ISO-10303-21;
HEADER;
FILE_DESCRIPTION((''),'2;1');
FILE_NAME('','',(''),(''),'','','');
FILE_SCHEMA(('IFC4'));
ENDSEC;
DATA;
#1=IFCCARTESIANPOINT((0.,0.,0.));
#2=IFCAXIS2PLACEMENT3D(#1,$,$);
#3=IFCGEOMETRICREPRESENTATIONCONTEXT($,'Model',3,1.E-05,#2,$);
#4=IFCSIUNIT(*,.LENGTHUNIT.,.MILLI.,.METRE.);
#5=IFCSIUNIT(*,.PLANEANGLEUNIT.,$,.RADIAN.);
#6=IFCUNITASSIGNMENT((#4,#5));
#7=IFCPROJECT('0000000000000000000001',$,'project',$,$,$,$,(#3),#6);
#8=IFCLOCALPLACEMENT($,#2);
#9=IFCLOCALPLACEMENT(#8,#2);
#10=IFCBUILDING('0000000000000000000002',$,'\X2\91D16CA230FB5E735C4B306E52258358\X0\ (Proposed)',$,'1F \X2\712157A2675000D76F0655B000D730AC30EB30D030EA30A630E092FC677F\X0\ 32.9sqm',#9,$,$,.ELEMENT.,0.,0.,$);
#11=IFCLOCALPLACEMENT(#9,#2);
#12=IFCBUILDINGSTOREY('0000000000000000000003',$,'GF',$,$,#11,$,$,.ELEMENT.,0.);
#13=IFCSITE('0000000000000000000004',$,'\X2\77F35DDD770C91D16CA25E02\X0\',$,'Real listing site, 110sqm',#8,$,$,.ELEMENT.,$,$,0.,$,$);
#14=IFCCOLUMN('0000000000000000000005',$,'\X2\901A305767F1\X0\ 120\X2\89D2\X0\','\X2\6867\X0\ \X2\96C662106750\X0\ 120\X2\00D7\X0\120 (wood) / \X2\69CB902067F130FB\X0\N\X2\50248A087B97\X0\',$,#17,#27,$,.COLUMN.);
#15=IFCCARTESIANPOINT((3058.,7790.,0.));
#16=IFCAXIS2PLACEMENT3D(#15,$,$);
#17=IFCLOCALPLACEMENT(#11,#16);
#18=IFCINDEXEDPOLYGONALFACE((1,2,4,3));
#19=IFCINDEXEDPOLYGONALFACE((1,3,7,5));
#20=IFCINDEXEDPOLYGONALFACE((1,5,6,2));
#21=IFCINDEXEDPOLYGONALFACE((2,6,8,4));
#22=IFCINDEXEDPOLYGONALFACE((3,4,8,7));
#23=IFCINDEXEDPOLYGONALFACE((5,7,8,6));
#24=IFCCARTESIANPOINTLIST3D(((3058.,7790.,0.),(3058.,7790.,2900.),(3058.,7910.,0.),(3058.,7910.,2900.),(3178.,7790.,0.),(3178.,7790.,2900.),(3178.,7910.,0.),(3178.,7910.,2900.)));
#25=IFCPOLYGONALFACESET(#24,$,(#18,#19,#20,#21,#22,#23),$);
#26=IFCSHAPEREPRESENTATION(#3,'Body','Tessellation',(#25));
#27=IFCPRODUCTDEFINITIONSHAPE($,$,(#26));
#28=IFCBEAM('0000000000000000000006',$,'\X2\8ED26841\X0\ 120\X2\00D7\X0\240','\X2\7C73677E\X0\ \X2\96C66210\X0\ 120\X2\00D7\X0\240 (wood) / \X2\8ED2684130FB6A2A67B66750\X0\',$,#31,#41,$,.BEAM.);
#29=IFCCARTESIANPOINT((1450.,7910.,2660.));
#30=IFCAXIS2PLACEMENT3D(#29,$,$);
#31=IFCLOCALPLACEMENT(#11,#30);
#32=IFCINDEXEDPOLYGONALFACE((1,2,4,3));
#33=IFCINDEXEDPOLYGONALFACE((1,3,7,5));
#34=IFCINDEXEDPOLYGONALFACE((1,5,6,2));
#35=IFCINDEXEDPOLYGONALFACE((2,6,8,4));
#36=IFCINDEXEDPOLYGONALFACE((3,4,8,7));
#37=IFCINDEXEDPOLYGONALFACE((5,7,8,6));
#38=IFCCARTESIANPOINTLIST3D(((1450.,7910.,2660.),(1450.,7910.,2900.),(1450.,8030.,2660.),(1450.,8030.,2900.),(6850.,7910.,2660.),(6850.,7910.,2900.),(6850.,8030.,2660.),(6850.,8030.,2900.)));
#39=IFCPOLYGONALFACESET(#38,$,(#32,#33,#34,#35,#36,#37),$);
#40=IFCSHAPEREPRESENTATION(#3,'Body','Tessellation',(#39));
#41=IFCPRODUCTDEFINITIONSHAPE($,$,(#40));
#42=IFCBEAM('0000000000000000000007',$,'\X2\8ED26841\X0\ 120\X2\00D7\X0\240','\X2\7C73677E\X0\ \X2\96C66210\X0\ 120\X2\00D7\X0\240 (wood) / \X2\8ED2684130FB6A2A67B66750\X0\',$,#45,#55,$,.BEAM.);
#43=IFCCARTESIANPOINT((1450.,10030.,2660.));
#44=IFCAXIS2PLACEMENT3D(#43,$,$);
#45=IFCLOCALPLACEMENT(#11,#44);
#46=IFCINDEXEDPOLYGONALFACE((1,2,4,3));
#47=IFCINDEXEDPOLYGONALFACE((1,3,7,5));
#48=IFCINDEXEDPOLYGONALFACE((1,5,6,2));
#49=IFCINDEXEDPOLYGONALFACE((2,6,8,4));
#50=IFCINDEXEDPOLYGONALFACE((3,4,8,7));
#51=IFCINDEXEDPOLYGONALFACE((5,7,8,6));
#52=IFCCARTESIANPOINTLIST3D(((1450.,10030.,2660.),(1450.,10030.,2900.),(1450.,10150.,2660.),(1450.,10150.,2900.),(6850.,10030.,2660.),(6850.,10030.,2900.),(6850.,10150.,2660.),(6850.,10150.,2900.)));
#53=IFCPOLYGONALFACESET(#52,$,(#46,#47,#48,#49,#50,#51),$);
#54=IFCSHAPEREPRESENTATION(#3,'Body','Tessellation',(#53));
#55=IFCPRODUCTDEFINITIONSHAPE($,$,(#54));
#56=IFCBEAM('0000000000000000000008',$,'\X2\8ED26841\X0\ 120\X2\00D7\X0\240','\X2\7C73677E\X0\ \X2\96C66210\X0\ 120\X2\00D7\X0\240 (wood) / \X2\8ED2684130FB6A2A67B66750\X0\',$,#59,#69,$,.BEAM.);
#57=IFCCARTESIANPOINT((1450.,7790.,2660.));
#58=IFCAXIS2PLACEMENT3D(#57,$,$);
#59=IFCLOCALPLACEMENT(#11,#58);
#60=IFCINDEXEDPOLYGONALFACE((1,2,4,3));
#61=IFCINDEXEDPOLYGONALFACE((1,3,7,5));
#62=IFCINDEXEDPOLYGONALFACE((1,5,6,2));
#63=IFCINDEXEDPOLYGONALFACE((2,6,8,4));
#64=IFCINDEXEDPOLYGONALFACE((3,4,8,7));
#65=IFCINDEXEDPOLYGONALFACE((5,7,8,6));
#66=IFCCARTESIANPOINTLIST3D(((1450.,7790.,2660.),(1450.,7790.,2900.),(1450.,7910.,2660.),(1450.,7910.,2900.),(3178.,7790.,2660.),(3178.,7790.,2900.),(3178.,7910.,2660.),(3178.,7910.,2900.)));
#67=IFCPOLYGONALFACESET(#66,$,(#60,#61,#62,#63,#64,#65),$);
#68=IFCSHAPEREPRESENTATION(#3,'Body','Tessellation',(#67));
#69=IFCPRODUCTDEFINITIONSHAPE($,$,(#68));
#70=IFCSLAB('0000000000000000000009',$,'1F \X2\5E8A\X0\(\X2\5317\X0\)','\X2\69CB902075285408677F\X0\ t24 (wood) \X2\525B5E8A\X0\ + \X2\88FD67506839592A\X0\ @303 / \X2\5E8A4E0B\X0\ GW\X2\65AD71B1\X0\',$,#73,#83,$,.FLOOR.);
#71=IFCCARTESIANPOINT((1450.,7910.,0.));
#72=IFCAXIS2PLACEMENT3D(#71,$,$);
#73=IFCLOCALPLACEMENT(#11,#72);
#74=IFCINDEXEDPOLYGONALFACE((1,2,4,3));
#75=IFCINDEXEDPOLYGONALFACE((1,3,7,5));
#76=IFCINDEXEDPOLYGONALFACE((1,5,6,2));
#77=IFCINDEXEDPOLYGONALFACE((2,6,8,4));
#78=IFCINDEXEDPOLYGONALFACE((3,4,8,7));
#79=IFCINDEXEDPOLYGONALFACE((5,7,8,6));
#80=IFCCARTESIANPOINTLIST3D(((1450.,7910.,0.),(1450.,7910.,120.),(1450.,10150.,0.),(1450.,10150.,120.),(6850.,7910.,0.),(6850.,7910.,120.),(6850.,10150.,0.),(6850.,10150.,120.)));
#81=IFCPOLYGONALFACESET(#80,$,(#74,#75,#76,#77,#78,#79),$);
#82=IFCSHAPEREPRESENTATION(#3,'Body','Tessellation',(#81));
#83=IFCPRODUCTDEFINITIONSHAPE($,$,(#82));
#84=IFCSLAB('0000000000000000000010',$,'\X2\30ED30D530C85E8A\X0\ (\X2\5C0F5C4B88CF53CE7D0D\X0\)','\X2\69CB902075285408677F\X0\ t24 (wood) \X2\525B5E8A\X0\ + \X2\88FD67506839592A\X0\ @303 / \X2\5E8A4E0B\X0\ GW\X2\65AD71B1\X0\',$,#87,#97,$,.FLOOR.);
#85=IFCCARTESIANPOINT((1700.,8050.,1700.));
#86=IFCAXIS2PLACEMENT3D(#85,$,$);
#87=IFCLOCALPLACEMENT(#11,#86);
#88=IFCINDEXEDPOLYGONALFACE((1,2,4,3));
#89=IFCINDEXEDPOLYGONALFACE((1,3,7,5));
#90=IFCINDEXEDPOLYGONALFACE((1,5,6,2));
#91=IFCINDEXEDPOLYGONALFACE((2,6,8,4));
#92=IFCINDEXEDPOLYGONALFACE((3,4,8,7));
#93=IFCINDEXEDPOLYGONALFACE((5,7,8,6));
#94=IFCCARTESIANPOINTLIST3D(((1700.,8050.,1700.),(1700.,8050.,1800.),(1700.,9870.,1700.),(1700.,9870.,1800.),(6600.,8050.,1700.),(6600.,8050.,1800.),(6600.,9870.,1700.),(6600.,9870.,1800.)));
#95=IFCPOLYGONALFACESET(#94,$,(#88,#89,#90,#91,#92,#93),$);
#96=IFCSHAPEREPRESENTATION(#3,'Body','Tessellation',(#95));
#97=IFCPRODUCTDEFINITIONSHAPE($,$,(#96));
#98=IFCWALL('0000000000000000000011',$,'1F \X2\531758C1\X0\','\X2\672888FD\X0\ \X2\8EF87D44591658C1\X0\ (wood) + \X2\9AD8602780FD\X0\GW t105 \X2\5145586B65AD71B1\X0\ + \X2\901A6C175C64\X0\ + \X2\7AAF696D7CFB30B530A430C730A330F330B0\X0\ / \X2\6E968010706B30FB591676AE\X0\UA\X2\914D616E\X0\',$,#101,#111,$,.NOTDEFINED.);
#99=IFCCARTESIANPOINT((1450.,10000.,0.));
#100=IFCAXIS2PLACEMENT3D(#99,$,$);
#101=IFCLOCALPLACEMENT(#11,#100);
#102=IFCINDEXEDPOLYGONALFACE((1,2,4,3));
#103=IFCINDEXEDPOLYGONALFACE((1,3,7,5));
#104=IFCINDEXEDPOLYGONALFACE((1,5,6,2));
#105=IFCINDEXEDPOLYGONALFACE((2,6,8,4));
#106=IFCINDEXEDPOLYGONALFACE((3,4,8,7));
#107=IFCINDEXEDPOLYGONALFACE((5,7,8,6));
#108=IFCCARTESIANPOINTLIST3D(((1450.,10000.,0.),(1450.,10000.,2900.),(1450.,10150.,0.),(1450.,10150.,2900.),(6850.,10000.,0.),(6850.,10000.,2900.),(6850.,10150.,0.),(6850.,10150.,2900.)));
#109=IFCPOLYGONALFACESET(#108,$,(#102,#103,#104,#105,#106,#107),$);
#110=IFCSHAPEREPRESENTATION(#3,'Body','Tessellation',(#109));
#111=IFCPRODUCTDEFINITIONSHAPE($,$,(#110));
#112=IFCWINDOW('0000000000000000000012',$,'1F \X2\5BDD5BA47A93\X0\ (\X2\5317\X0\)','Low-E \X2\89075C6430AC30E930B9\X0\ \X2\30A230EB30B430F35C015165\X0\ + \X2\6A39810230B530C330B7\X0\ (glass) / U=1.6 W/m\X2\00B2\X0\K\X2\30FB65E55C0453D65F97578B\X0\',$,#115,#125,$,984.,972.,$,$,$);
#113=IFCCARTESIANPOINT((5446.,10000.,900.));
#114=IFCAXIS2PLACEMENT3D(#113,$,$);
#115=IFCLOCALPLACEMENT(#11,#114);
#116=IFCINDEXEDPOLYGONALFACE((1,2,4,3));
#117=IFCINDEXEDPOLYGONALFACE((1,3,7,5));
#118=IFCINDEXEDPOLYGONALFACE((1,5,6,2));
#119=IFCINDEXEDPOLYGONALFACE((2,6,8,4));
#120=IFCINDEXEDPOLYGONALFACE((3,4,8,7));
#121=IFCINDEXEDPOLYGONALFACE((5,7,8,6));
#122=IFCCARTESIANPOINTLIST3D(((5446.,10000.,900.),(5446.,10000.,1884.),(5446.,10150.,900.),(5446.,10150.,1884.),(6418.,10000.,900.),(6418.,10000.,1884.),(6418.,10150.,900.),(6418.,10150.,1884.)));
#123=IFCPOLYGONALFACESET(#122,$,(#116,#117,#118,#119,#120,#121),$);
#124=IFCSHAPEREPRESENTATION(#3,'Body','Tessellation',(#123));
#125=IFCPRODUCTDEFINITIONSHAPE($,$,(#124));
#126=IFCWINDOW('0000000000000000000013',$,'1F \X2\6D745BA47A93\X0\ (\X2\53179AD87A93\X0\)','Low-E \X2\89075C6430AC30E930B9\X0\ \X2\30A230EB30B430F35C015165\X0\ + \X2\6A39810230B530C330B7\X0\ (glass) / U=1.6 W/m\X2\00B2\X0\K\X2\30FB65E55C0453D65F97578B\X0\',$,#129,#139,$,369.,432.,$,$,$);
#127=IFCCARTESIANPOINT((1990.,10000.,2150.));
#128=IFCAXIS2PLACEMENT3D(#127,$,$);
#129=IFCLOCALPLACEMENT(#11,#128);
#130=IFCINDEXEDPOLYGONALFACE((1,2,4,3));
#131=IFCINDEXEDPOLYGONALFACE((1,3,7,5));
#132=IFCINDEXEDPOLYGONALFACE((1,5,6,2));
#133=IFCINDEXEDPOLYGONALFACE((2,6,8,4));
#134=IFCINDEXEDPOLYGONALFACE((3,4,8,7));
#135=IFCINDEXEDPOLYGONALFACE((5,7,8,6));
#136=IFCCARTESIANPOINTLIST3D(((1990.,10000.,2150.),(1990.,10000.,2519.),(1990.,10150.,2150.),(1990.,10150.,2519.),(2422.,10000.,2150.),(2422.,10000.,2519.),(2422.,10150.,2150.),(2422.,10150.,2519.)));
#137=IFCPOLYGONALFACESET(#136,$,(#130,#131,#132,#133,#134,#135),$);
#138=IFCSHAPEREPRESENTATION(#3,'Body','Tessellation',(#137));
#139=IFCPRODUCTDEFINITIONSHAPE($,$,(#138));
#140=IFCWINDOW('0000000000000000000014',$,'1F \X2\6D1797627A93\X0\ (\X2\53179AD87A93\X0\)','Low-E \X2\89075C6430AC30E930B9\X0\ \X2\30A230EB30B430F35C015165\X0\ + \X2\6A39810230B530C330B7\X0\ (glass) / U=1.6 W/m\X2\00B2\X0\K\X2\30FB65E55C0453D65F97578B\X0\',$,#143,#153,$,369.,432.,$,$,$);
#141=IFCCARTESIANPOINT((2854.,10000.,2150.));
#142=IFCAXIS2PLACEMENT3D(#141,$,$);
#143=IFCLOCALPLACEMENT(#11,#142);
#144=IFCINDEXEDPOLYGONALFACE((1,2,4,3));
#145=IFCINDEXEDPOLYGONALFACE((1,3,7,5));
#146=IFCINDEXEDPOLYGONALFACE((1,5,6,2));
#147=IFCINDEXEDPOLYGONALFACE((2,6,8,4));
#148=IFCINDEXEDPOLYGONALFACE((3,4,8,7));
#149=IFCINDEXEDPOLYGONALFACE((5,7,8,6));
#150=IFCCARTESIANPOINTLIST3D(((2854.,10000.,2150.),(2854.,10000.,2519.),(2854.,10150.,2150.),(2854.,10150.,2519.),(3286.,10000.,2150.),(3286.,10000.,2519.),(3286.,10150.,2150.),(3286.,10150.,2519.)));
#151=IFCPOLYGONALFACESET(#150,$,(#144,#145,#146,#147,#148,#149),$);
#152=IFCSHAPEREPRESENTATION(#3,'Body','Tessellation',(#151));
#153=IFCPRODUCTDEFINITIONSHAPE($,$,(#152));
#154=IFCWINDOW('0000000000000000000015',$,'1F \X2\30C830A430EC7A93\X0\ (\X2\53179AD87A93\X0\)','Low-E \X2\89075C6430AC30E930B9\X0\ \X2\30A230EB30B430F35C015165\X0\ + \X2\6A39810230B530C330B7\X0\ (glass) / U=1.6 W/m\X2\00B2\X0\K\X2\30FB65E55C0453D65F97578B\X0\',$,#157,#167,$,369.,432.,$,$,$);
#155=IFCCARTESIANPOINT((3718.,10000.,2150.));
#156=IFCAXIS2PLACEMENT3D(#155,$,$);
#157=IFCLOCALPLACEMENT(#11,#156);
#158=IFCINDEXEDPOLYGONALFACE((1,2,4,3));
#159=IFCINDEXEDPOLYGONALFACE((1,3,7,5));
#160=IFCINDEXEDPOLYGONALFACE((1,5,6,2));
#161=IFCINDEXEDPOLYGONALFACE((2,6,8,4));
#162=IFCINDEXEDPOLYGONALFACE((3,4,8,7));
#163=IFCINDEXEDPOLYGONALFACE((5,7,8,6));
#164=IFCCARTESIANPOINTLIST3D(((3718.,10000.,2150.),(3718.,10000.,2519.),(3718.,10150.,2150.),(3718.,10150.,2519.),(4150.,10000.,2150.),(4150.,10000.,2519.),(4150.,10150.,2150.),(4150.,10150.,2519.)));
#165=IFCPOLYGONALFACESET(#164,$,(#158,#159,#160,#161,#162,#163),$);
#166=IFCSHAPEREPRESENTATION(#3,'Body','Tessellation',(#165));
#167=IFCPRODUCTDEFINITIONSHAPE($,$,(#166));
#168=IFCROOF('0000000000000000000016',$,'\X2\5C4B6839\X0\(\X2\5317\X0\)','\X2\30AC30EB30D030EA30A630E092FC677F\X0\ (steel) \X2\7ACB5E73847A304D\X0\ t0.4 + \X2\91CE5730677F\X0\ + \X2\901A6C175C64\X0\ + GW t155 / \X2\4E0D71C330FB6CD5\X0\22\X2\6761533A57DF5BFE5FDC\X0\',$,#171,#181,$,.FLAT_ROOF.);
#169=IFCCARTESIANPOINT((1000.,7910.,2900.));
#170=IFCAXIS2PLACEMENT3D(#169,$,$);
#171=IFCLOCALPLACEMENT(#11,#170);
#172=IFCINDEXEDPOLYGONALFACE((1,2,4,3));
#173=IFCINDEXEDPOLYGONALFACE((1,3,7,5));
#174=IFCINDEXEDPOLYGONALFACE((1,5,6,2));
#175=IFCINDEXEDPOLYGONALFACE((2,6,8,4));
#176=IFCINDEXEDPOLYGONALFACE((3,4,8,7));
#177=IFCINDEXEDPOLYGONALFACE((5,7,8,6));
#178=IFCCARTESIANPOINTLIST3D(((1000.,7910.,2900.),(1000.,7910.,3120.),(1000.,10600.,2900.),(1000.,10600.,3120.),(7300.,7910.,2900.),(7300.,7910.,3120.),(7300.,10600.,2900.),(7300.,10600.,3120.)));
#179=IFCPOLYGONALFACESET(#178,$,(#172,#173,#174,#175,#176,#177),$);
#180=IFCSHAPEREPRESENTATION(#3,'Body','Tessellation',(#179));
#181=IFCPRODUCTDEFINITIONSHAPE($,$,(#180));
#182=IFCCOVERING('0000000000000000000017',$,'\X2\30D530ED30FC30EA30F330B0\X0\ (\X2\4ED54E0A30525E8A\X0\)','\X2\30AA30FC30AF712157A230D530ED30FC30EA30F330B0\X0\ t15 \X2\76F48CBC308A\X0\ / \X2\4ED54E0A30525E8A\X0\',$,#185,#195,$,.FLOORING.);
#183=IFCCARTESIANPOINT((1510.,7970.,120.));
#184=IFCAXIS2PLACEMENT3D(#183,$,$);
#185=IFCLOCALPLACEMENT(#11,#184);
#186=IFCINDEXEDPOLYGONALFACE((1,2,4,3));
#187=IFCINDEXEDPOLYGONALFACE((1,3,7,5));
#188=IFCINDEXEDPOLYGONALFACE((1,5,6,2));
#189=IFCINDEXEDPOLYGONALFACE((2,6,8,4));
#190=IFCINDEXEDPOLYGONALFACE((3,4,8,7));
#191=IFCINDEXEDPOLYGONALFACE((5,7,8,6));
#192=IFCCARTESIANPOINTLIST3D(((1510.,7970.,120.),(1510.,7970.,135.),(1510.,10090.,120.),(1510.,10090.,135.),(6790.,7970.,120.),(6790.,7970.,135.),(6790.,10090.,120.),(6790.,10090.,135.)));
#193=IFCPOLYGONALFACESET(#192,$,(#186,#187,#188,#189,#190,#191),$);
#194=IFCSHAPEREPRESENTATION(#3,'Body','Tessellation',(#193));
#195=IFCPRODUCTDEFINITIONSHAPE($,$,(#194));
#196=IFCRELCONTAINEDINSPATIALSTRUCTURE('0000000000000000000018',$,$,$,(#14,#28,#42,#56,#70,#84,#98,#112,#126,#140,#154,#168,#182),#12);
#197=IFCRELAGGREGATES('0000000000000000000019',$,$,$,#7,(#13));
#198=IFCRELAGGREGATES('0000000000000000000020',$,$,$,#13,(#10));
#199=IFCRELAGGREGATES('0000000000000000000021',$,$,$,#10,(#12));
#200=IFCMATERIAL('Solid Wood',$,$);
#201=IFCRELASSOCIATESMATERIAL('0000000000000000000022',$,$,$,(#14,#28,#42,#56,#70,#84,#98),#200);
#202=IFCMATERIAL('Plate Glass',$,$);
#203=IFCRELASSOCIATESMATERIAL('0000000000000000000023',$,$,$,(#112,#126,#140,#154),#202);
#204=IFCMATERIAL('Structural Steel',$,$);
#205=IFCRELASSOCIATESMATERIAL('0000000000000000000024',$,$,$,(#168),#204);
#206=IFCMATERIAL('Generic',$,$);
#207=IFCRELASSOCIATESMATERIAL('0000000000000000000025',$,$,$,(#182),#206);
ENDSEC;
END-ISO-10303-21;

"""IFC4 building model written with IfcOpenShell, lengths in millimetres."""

from ifc_helpers import new_model, si_unit, frame, frame_2d, origin, place, context, project, spatial, rectangle, extrude, material, element, fill, save


model = new_model("IFC4")

# Units and contexts
model_context = context("Model", 3, precision=1e-05, world=origin())
ifc_project = project(units=[si_unit("LENGTHUNIT", "METRE", prefix="MILLI"), si_unit("PLANEANGLEUNIT", "RADIAN")], contexts=[model_context])

# Site, building, storey
site_placement = place(None, origin())
site = spatial("IfcSite", under=ifc_project, at=site_placement, Name="石川県金沢市", ObjectType="Real listing site, 110sqm", CompositionType="ELEMENT", RefElevation=0.0)
building_placement = place(site_placement, origin())
building = spatial("IfcBuilding", under=site, at=building_placement, Name="金沢・平屋の別荘 (Proposed)", ObjectType="1F 無垢材×漆喰×ガルバリウム鋼板 32.9sqm", CompositionType="ELEMENT", ElevationOfRefHeight=0.0, ElevationOfTerrain=0.0)
storey_placement = place(building_placement, origin())
storey = spatial("IfcBuildingStorey", under=building, at=storey_placement, Name="GF", CompositionType="ELEMENT", Elevation=0.0)

# Column
ifc_material_1 = material(Name="Solid Wood")
column_1_placement = place(storey_placement, frame((3058.0, 7790.0, 0.0)))
element("IfcColumn", 1, at=column_1_placement, inside=storey, material=ifc_material_1, Name="通し柱 120角", Description="桧 集成材 120×120 (wood) / 構造柱・N値計算", PredefinedType="COLUMN", context=model_context, shape_type="SweptSolid", body=[
    extrude(rectangle(XDim=120.0, YDim=120.0, at=frame_2d((60.0, 60.0))), frame((3058.0, 7790.0, 0.0)), (0.0, 0.0, 1.0), 2900.0),
])

# Beams
beam_1_placement = place(storey_placement, frame((1450.0, 7910.0, 2660.0)))
element("IfcBeam", 2, at=beam_1_placement, inside=storey, material=ifc_material_1, Name="軒桁 120×240", Description="米松 集成 120×240 (wood) / 軒桁・横架材", PredefinedType="BEAM", context=model_context, shape_type="SweptSolid", body=[
    extrude(rectangle(XDim=5400.0, YDim=120.0, at=frame_2d((2700.0, 60.0))), frame((1450.0, 7910.0, 2660.0)), (0.0, 0.0, 1.0), 240.0),
])
beam_2_placement = place(storey_placement, frame((1450.0, 10030.0, 2660.0)))
element("IfcBeam", 3, at=beam_2_placement, inside=storey, material=ifc_material_1, Name="軒桁 120×240", Description="米松 集成 120×240 (wood) / 軒桁・横架材", PredefinedType="BEAM", context=model_context, shape_type="SweptSolid", body=[
    extrude(rectangle(XDim=5400.0, YDim=120.0, at=frame_2d((2700.0, 60.0))), frame((1450.0, 10030.0, 2660.0)), (0.0, 0.0, 1.0), 240.0),
])
beam_3_placement = place(storey_placement, frame((1450.0, 7790.0, 2660.0)))
element("IfcBeam", 4, at=beam_3_placement, inside=storey, material=ifc_material_1, Name="軒桁 120×240", Description="米松 集成 120×240 (wood) / 軒桁・横架材", PredefinedType="BEAM", context=model_context, shape_type="SweptSolid", body=[
    extrude(rectangle(XDim=1728.0, YDim=120.0, at=frame_2d((864.0, 60.0))), frame((1450.0, 7790.0, 2660.0)), (0.0, 0.0, 1.0), 240.0),
])

# Slabs
slab_1_placement = place(storey_placement, frame((1450.0, 7910.0, 0.0)))
element("IfcSlab", 5, at=slab_1_placement, inside=storey, material=ifc_material_1, Name="1F 床(北)", Description="構造用合板 t24 (wood) 剛床 + 製材根太 @303 / 床下 GW断熱", PredefinedType="FLOOR", context=model_context, shape_type="SweptSolid", body=[
    extrude(rectangle(XDim=5400.0, YDim=2240.0, at=frame_2d((2700.0, 1120.0))), frame((1450.0, 7910.0, 0.0)), (0.0, 0.0, 1.0), 120.0),
])
slab_2_placement = place(storey_placement, frame((1700.0, 8050.0, 1700.0)))
element("IfcSlab", 6, at=slab_2_placement, inside=storey, material=ifc_material_1, Name="ロフト床 (小屋裏収納)", Description="構造用合板 t24 (wood) 剛床 + 製材根太 @303 / 床下 GW断熱", PredefinedType="FLOOR", context=model_context, shape_type="SweptSolid", body=[
    extrude(rectangle(XDim=4900.0, YDim=1820.0, at=frame_2d((2450.0, 910.0))), frame((1700.0, 8050.0, 1700.0)), (0.0, 0.0, 1.0), 100.0),
])

# Wall, openings, windows
wall_1_placement = place(storey_placement, frame((1450.0, 10000.0, 0.0)))
wall_1 = element("IfcWall", 7, at=wall_1_placement, inside=storey, material=ifc_material_1, Name="1F 北壁", Description="木製 軸組外壁 (wood) + 高性能GW t105 充填断熱 + 通気層 + 窯業系サイディング / 準耐火・外皮UA配慮", PredefinedType="NOTDEFINED", context=model_context, shape_type="SweptSolid", body=[
    extrude(rectangle(XDim=5400.0, YDim=150.0, at=frame_2d((2700.0, 75.0))), frame((1450.0, 10000.0, 0.0)), (0.0, 0.0, 1.0), 2900.0),
])
opening_1_placement = place(storey_placement, frame((5446.0, 10000.0, 900.0)))
opening_1 = element("IfcOpeningElement", 8, at=opening_1_placement, cuts=wall_1, PredefinedType="NOTDEFINED", context=model_context, shape_type="SweptSolid", body=[
    extrude(rectangle(XDim=972.0, YDim=150.0, at=frame_2d((486.0, 75.0))), frame((5446.0, 10000.0, 900.0)), (0.0, 0.0, 1.0), 984.0),
])
opening_2_placement = place(storey_placement, frame((1990.0, 10000.0, 2150.0)))
opening_2 = element("IfcOpeningElement", 9, at=opening_2_placement, cuts=wall_1, PredefinedType="NOTDEFINED", context=model_context, shape_type="SweptSolid", body=[
    extrude(rectangle(XDim=432.0, YDim=150.0, at=frame_2d((216.0, 75.0))), frame((1990.0, 10000.0, 2150.0)), (0.0, 0.0, 1.0), 369.0),
])
opening_3_placement = place(storey_placement, frame((2854.0, 10000.0, 2150.0)))
opening_3 = element("IfcOpeningElement", 10, at=opening_3_placement, cuts=wall_1, PredefinedType="NOTDEFINED", context=model_context, shape_type="SweptSolid", body=[
    extrude(rectangle(XDim=432.0, YDim=150.0, at=frame_2d((216.0, 75.0))), frame((2854.0, 10000.0, 2150.0)), (0.0, 0.0, 1.0), 369.0),
])
opening_4_placement = place(storey_placement, frame((3718.0, 10000.0, 2150.0)))
opening_4 = element("IfcOpeningElement", 11, at=opening_4_placement, cuts=wall_1, PredefinedType="NOTDEFINED", context=model_context, shape_type="SweptSolid", body=[
    extrude(rectangle(XDim=432.0, YDim=150.0, at=frame_2d((216.0, 75.0))), frame((3718.0, 10000.0, 2150.0)), (0.0, 0.0, 1.0), 369.0),
])
ifc_material_2 = material(Name="Plate Glass")
window_1_placement = place(storey_placement, frame((5446.0, 10000.0, 900.0)))
window_1 = element("IfcWindow", 12, at=window_1_placement, inside=storey, material=ifc_material_2, Name="1F 寝室窓 (北)", Description="Low-E 複層ガラス アルゴン封入 + 樹脂サッシ (glass) / U=1.6 W/m²K・日射取得型", OverallHeight=984.0, OverallWidth=972.0, context=model_context, shape_type="SweptSolid", body=[
    extrude(rectangle(XDim=972.0, YDim=150.0, at=frame_2d((486.0, 75.0))), frame((5446.0, 10000.0, 900.0)), (0.0, 0.0, 1.0), 984.0),
])
fill(opening_1, window_1)
window_2_placement = place(storey_placement, frame((1990.0, 10000.0, 2150.0)))
window_2 = element("IfcWindow", 13, at=window_2_placement, inside=storey, material=ifc_material_2, Name="1F 浴室窓 (北高窓)", Description="Low-E 複層ガラス アルゴン封入 + 樹脂サッシ (glass) / U=1.6 W/m²K・日射取得型", OverallHeight=369.0, OverallWidth=432.0, context=model_context, shape_type="SweptSolid", body=[
    extrude(rectangle(XDim=432.0, YDim=150.0, at=frame_2d((216.0, 75.0))), frame((1990.0, 10000.0, 2150.0)), (0.0, 0.0, 1.0), 369.0),
])
fill(opening_2, window_2)
window_3_placement = place(storey_placement, frame((2854.0, 10000.0, 2150.0)))
window_3 = element("IfcWindow", 14, at=window_3_placement, inside=storey, material=ifc_material_2, Name="1F 洗面窓 (北高窓)", Description="Low-E 複層ガラス アルゴン封入 + 樹脂サッシ (glass) / U=1.6 W/m²K・日射取得型", OverallHeight=369.0, OverallWidth=432.0, context=model_context, shape_type="SweptSolid", body=[
    extrude(rectangle(XDim=432.0, YDim=150.0, at=frame_2d((216.0, 75.0))), frame((2854.0, 10000.0, 2150.0)), (0.0, 0.0, 1.0), 369.0),
])
fill(opening_3, window_3)
window_4_placement = place(storey_placement, frame((3718.0, 10000.0, 2150.0)))
window_4 = element("IfcWindow", 15, at=window_4_placement, inside=storey, material=ifc_material_2, Name="1F トイレ窓 (北高窓)", Description="Low-E 複層ガラス アルゴン封入 + 樹脂サッシ (glass) / U=1.6 W/m²K・日射取得型", OverallHeight=369.0, OverallWidth=432.0, context=model_context, shape_type="SweptSolid", body=[
    extrude(rectangle(XDim=432.0, YDim=150.0, at=frame_2d((216.0, 75.0))), frame((3718.0, 10000.0, 2150.0)), (0.0, 0.0, 1.0), 369.0),
])
fill(opening_4, window_4)

# Roof
ifc_material_3 = material(Name="Structural Steel")
roof_placement = place(storey_placement, frame((1000.0, 7910.0, 2900.0)))
element("IfcRoof", 16, at=roof_placement, inside=storey, material=ifc_material_3, Name="屋根(北)", Description="ガルバリウム鋼板 (steel) 立平葺き t0.4 + 野地板 + 通気層 + GW t155 / 不燃・法22条区域対応", PredefinedType="FLAT_ROOF", context=model_context, shape_type="SweptSolid", body=[
    extrude(rectangle(XDim=6300.0, YDim=2690.0, at=frame_2d((3150.0, 1345.0))), frame((1000.0, 7910.0, 2900.0)), (0.0, 0.0, 1.0), 220.0),
])

# Covering
ifc_material_4 = material(Name="Generic")
covering_1_placement = place(storey_placement, frame((1510.0, 7970.0, 120.0)))
element("IfcCovering", 17, at=covering_1_placement, inside=storey, material=ifc_material_4, Name="フローリング (仕上げ床)", Description="オーク無垢フローリング t15 直貼り / 仕上げ床", PredefinedType="FLOORING", context=model_context, shape_type="SweptSolid", body=[
    extrude(rectangle(XDim=5280.0, YDim=2120.0, at=frame_2d((2640.0, 1060.0))), frame((1510.0, 7970.0, 120.0)), (0.0, 0.0, 1.0), 15.0),
])

save(model, "model.ifc")
